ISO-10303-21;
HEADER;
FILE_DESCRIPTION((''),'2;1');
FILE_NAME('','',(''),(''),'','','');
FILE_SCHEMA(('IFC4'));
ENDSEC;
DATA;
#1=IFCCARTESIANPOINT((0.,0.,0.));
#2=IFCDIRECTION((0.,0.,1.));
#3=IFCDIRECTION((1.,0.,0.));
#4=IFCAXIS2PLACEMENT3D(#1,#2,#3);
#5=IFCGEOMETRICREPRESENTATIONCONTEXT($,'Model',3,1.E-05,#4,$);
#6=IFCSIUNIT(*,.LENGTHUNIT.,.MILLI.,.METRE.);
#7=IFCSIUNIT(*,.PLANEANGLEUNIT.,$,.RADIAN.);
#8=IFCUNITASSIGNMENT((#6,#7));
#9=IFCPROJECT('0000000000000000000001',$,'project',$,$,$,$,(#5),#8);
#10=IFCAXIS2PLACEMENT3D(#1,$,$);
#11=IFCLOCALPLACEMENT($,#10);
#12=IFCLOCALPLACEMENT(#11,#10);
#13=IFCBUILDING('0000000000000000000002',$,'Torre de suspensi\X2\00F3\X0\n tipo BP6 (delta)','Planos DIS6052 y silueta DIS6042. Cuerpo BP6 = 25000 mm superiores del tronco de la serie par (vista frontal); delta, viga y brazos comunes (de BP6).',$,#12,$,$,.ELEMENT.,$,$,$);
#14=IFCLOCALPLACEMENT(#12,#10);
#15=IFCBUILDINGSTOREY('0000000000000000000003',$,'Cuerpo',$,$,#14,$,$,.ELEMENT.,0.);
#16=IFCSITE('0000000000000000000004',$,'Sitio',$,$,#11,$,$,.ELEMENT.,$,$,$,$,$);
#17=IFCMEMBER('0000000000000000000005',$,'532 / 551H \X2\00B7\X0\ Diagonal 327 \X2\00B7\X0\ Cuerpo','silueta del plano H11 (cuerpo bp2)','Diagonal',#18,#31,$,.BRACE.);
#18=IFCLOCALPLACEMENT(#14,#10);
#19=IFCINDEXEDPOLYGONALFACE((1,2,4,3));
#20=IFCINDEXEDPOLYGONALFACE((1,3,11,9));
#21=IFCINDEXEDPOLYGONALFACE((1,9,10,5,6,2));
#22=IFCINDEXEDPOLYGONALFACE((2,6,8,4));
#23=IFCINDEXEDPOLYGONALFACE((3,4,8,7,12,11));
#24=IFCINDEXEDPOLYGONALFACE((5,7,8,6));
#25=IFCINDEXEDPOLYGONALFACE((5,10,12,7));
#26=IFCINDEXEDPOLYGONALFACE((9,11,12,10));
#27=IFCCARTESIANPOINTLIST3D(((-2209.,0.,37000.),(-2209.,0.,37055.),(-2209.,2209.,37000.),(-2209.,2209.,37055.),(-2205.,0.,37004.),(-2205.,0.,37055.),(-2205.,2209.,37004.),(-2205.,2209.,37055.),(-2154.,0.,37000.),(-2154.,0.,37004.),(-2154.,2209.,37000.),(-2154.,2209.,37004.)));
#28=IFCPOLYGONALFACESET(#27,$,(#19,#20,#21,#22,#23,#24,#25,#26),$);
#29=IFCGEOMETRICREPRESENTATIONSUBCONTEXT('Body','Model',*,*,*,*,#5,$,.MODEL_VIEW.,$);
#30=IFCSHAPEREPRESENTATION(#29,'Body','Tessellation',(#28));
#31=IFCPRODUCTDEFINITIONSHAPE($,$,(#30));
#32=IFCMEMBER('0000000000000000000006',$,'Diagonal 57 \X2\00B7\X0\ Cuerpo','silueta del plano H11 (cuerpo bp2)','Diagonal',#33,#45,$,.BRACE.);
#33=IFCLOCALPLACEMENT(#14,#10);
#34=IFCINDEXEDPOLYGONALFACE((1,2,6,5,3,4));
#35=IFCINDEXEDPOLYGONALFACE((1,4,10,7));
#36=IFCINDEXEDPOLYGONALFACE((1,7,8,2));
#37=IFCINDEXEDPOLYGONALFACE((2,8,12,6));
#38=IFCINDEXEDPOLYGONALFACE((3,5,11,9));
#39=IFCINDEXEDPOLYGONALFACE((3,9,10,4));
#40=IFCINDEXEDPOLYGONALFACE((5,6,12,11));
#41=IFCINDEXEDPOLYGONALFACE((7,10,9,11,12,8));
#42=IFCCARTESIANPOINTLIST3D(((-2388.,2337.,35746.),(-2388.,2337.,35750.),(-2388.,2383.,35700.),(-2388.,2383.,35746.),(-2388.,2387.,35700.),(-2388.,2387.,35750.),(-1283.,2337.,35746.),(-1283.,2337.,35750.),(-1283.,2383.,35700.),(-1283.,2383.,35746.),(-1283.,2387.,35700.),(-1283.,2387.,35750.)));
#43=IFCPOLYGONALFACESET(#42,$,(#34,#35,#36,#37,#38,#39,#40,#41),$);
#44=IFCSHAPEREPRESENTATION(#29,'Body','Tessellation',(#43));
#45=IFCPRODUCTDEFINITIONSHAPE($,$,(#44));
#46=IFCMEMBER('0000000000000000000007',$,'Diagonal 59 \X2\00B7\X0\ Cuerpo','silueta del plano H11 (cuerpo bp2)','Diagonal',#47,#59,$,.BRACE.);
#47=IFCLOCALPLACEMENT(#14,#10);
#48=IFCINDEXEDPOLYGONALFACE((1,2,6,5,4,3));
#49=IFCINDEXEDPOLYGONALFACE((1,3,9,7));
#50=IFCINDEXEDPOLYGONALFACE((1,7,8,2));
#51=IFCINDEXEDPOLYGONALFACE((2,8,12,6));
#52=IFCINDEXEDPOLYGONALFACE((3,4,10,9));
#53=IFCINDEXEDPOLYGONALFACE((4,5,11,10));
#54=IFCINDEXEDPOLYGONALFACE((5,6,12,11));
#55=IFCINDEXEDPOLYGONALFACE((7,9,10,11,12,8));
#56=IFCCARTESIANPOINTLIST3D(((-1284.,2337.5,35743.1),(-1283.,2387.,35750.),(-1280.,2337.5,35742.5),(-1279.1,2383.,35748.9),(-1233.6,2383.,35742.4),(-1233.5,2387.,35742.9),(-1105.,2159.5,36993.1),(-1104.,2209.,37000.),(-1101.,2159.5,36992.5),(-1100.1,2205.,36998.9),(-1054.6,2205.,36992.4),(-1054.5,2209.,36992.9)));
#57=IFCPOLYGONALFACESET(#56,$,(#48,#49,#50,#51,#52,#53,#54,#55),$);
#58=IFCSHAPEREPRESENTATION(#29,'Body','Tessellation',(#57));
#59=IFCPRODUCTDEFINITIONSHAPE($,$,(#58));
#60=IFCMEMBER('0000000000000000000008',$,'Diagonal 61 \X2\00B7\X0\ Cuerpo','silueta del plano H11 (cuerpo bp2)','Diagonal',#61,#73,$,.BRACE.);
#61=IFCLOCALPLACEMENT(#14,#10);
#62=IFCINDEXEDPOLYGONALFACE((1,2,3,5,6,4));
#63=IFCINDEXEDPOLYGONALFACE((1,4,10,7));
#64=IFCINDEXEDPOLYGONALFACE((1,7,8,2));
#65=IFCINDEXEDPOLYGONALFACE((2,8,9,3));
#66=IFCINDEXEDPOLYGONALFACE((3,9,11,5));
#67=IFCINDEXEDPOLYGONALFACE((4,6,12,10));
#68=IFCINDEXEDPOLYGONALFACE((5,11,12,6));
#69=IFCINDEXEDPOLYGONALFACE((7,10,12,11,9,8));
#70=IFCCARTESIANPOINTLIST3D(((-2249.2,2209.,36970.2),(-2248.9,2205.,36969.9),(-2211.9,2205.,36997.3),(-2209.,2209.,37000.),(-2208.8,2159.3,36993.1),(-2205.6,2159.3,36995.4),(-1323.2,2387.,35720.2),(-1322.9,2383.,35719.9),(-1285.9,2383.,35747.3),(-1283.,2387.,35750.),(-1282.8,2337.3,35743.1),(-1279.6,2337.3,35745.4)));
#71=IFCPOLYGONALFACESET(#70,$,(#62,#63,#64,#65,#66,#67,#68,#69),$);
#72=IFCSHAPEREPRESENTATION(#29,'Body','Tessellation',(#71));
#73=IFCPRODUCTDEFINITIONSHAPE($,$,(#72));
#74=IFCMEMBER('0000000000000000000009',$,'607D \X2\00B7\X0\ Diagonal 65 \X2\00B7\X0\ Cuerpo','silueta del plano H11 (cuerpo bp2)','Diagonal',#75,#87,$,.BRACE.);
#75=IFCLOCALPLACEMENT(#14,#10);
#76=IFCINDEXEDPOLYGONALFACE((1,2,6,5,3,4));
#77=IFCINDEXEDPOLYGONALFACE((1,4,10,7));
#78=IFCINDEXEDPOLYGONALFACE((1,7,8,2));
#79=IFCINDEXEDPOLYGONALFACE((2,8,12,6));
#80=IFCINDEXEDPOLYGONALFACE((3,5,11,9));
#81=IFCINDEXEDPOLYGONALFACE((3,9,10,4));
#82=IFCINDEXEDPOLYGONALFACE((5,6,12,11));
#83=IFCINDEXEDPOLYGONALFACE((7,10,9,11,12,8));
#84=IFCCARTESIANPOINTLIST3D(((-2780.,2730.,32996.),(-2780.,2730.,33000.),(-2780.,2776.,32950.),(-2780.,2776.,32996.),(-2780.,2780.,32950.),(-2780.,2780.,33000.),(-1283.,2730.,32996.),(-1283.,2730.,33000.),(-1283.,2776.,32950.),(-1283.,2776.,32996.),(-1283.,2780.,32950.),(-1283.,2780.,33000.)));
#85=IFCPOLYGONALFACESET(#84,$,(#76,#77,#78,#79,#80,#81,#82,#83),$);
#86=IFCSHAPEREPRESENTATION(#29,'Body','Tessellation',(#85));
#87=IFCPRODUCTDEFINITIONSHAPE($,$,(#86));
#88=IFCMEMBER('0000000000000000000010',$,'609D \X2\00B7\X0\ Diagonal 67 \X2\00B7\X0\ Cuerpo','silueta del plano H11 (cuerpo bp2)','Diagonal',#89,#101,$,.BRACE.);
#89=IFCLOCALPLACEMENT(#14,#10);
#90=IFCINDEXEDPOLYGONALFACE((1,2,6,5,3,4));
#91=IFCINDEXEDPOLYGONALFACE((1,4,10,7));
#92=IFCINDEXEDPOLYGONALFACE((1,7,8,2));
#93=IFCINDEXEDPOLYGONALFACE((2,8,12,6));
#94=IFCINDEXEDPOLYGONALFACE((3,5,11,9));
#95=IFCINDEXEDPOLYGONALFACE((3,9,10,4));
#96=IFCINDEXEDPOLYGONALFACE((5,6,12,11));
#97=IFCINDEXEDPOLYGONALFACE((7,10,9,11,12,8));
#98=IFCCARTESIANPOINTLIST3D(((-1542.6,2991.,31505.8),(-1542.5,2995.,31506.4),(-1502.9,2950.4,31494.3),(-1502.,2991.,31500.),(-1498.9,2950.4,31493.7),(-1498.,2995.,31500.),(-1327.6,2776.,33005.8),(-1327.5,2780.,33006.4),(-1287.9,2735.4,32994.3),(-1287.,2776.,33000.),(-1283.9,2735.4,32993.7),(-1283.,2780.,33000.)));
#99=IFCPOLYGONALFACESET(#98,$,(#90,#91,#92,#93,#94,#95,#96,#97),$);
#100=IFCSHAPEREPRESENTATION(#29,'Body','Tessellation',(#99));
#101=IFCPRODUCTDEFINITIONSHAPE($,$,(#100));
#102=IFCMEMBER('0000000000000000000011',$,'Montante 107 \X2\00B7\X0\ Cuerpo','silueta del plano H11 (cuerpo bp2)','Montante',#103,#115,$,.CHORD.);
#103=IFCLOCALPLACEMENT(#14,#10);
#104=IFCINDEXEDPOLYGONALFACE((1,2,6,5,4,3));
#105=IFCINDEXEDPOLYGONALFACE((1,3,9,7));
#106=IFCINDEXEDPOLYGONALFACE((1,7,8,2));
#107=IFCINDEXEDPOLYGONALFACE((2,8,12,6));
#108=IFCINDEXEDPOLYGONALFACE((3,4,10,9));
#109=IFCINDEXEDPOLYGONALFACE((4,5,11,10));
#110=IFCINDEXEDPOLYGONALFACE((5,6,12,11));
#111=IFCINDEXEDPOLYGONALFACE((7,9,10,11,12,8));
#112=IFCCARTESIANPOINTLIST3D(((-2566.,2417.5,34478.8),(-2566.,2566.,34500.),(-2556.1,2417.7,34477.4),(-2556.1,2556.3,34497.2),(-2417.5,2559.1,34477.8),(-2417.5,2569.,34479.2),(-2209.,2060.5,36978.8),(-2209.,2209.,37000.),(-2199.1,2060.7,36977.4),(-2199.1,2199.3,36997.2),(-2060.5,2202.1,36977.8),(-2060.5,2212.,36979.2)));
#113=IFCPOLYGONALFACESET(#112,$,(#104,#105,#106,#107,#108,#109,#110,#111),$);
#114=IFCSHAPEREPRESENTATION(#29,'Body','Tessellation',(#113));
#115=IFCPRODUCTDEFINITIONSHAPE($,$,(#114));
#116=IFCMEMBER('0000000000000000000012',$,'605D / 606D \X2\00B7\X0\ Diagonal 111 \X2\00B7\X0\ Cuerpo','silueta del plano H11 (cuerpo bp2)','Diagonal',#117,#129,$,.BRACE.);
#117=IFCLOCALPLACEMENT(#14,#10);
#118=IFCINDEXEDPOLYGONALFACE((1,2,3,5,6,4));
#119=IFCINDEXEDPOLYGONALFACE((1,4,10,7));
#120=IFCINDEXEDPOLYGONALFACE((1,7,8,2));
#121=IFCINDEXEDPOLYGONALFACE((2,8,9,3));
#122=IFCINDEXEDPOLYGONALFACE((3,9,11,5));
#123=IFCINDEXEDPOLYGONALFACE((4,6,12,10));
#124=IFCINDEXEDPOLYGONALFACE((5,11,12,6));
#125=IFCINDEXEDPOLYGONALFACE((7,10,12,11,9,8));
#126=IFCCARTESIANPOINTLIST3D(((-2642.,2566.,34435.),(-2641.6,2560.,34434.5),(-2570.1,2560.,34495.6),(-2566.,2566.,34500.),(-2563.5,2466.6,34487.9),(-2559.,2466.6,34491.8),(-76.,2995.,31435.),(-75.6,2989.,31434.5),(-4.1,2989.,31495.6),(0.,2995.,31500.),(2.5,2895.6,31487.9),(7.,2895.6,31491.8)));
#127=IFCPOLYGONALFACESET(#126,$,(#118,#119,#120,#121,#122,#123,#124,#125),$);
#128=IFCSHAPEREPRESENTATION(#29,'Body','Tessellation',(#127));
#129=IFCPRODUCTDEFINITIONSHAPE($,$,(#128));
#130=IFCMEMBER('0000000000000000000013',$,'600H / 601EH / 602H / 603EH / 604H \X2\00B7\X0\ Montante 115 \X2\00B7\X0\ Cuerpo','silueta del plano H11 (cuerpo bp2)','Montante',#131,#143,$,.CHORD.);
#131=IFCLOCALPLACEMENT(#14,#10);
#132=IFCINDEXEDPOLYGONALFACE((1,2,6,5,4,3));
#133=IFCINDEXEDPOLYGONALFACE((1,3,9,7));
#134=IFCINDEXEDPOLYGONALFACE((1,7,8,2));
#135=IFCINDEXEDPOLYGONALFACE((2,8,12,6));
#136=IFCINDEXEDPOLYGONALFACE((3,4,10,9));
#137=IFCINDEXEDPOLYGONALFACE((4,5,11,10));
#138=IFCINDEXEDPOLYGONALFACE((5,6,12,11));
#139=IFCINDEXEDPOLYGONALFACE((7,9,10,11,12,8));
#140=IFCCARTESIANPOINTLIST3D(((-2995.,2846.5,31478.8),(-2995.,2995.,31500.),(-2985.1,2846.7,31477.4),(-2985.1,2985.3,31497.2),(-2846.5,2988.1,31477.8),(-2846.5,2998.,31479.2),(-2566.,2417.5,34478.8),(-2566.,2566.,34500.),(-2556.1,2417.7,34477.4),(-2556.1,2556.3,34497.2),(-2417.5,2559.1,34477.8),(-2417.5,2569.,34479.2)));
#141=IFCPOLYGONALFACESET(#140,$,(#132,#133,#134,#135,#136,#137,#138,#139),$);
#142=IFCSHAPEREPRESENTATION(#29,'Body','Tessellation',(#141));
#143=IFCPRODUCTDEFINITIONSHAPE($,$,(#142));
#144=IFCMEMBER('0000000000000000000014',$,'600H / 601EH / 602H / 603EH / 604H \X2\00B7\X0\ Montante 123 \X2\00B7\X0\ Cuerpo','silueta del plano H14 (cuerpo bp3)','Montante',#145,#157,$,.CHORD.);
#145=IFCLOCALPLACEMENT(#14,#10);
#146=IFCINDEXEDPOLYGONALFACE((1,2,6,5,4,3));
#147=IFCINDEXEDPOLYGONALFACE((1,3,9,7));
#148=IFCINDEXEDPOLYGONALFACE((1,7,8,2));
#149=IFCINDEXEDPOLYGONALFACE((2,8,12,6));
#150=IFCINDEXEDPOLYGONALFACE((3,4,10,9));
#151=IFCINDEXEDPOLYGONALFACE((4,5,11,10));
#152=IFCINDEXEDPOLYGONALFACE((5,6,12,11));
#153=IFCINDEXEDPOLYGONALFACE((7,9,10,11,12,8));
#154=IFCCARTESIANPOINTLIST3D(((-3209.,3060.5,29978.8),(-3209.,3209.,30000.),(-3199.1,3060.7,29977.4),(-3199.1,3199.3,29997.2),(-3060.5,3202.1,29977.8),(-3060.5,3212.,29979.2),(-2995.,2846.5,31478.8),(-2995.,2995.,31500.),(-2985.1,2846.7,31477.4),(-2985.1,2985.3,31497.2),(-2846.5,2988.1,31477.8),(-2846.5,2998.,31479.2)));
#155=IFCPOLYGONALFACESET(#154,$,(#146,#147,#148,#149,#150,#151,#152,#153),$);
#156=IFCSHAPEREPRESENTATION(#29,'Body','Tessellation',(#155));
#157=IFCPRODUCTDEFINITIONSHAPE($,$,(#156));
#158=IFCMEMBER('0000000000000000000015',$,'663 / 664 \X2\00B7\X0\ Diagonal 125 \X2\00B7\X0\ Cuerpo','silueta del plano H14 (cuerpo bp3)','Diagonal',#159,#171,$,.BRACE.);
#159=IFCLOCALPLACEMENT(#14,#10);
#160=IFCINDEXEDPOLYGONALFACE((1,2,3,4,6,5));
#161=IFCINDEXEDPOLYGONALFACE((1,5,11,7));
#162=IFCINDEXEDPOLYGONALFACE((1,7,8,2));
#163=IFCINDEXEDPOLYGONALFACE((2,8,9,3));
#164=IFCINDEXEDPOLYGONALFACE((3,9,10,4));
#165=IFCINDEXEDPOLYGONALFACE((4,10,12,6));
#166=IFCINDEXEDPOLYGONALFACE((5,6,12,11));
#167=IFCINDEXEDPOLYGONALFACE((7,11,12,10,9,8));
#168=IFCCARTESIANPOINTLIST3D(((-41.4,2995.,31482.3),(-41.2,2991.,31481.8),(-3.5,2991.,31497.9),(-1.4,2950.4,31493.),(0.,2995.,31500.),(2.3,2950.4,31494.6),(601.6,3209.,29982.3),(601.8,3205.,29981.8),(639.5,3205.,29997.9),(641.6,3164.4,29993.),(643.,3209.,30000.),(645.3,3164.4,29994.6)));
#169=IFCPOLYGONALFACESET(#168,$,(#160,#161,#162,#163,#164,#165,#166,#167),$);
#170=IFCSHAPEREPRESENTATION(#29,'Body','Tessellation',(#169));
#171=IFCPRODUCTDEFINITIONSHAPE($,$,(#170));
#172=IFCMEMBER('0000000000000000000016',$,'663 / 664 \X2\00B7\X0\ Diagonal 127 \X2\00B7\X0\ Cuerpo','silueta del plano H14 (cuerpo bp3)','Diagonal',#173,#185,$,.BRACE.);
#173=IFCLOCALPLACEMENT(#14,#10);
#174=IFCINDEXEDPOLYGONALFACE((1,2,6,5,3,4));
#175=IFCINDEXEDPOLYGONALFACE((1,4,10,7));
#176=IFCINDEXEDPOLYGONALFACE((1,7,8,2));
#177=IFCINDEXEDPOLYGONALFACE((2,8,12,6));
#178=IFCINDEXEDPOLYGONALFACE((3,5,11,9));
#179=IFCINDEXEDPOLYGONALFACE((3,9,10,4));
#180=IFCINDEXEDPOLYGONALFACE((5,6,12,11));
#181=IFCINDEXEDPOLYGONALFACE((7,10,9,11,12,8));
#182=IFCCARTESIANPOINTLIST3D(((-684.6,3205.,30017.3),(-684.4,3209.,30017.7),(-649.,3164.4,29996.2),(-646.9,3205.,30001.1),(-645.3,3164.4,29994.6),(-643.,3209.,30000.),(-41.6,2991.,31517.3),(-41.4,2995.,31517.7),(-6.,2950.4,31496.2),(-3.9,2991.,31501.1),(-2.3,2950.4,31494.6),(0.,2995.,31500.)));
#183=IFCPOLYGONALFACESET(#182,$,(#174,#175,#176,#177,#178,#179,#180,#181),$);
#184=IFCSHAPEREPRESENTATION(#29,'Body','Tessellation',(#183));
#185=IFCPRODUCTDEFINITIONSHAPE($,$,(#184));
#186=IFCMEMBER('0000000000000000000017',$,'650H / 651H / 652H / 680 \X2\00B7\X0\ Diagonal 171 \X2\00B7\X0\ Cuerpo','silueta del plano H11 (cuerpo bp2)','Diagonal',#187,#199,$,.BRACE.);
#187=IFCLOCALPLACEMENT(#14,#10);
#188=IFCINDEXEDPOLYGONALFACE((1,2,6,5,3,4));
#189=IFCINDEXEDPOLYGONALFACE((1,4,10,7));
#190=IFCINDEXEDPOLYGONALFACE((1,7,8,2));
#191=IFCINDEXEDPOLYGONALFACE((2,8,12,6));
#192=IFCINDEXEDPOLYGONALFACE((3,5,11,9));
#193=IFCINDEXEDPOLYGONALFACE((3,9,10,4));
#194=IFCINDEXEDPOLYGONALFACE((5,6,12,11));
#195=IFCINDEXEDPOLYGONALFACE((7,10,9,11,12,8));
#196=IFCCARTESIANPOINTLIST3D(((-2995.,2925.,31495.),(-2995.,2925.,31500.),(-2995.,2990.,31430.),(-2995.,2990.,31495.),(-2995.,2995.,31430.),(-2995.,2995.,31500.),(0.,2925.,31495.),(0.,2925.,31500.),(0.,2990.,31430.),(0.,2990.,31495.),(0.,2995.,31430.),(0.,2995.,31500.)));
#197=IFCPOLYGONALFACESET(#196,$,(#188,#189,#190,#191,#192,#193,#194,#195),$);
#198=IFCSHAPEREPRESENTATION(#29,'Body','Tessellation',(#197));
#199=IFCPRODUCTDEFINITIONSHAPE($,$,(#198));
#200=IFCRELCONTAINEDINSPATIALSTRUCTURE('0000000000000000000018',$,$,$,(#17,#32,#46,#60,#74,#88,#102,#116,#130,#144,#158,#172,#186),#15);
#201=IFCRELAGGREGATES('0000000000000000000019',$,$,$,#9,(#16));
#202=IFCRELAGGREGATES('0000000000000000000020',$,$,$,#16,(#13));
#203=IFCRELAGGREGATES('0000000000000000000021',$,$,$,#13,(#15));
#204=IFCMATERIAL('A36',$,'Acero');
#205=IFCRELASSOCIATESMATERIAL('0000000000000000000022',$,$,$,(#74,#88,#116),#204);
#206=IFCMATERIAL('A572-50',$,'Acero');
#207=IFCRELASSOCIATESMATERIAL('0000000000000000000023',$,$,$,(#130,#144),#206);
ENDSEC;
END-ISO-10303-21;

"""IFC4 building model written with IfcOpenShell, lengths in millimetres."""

from ifc_helpers import new_model, si_unit, frame, frame_2d, origin, origin_with_axes, place, context, subcontext, project, spatial, l_section, extrude, material, element, save


model = new_model("IFC4")

# Units and contexts
model_context = context("Model", 3, precision=1e-05, world=origin_with_axes())
body_context = subcontext(model_context, "Body", "Model", "MODEL_VIEW")
ifc_project = project(units=[si_unit("LENGTHUNIT", "METRE", prefix="MILLI"), si_unit("PLANEANGLEUNIT", "RADIAN")], contexts=[model_context])

# Site, building, storey
site_placement = place(None, origin())
site = spatial("IfcSite", under=ifc_project, at=site_placement, Name="Sitio", CompositionType="ELEMENT")
building_placement = place(site_placement, origin())
building = spatial("IfcBuilding", under=site, at=building_placement, Name="Torre de suspensión tipo BP6 (delta)", Description="Planos DIS6052 y silueta DIS6042. Cuerpo BP6 = 25000 mm superiores del tronco de la serie par (vista frontal); delta, viga y brazos comunes (de BP6).", CompositionType="ELEMENT")
storey_placement = place(building_placement, origin())
storey = spatial("IfcBuildingStorey", under=building, at=storey_placement, Name="Cuerpo", CompositionType="ELEMENT", Elevation=0.0)

# Members
member_1_placement = place(storey_placement, frame((-2209.0, 2209.0, 37000.0), z_axis=(0.0, -1.0, 0.0), x_axis=(1.0, 0.0, 0.0)))
element("IfcMember", 1, at=member_1_placement, inside=storey, Name="532 / 551H · Diagonal 327 · Cuerpo", Description="silueta del plano H11 (cuerpo bp2)", ObjectType="Diagonal", PredefinedType="BRACE", context=body_context, shape_type="SweptSolid", body=[
    extrude(l_section(Depth=55.0, Width=55.0, Thickness=4.0, at=frame_2d((27.5, 27.5))), None, (0.0, 0.0, 1.0), 2209.0),
])
member_2_placement = place(storey_placement, frame((-2388.0, 2387.0, 35750.0), z_axis=(1.0, 0.0, 0.0), x_axis=(0.0, -1.0, 0.0)))
element("IfcMember", 2, at=member_2_placement, inside=storey, Name="Diagonal 57 · Cuerpo", Description="silueta del plano H11 (cuerpo bp2)", ObjectType="Diagonal", PredefinedType="BRACE", context=body_context, shape_type="SweptSolid", body=[
    extrude(l_section(Depth=50.0, Width=50.0, Thickness=4.0, at=frame_2d((25.0, 25.0))), None, (0.0, 0.0, 1.0), 1105.0),
])
member_3_placement = place(storey_placement, frame((-1283.0, 2387.0, 35750.0), z_axis=(0.140366, -0.139582, 0.980211), x_axis=(-0.019786, -0.990211, -0.138173)))
element("IfcMember", 3, at=member_3_placement, inside=storey, Name="Diagonal 59 · Cuerpo", Description="silueta del plano H11 (cuerpo bp2)", ObjectType="Diagonal", PredefinedType="BRACE", context=body_context, shape_type="SweptSolid", body=[
    extrude(l_section(Depth=50.0, Width=50.0, Thickness=4.0, at=frame_2d((25.0, 25.0))), None, (0.0, 0.0, 1.0), 1275.2),
])
member_4_placement = place(storey_placement, frame((-2209.0, 2209.0, 37000.0), z_axis=(0.591399, 0.113682, -0.798325), x_axis=(0.06767, -0.993517, -0.091347)))
element("IfcMember", 4, at=member_4_placement, inside=storey, Name="Diagonal 61 · Cuerpo", Description="silueta del plano H11 (cuerpo bp2)", ObjectType="Diagonal", PredefinedType="BRACE", context=body_context, shape_type="SweptSolid", body=[
    extrude(l_section(Depth=50.0, Width=50.0, Thickness=4.0, at=frame_2d((25.0, 25.0))), None, (0.0, 0.0, 1.0), 1565.8),
])
ifc_material_1 = material(Name="A36", Category="Acero")
member_5_placement = place(storey_placement, frame((-2780.0, 2780.0, 33000.0), z_axis=(1.0, 0.0, 0.0), x_axis=(0.0, -1.0, 0.0)))
element("IfcMember", 5, at=member_5_placement, inside=storey, material=ifc_material_1, Name="607D · Diagonal 65 · Cuerpo", Description="silueta del plano H11 (cuerpo bp2)", ObjectType="Diagonal", PredefinedType="BRACE", context=body_context, shape_type="SweptSolid", body=[
    extrude(l_section(Depth=50.0, Width=50.0, Thickness=4.0, at=frame_2d((25.0, 25.0))), None, (0.0, 0.0, 1.0), 1497.0),
])
member_6_placement = place(storey_placement, frame((-1283.0, 2780.0, 33000.0), z_axis=(-0.140476, 0.140476, -0.980068), x_axis=(-0.019931, -0.990084, -0.139055)))
element("IfcMember", 6, at=member_6_placement, inside=storey, material=ifc_material_1, Name="609D · Diagonal 67 · Cuerpo", Description="silueta del plano H11 (cuerpo bp2)", ObjectType="Diagonal", PredefinedType="BRACE", context=body_context, shape_type="SweptSolid", body=[
    extrude(l_section(Depth=45.0, Width=45.0, Thickness=4.0, at=frame_2d((22.5, 22.5))), None, (0.0, 0.0, 1.0), 1530.5),
])
member_7_placement = place(storey_placement, frame((-2209.0, 2209.0, 37000.0), z_axis=(-0.139974, 0.139974, -0.980211), x_axis=(0.990155, 0.019788, -0.138568)))
element("IfcMember", 7, at=member_7_placement, inside=storey, Name="Montante 107 · Cuerpo", Description="silueta del plano H11 (cuerpo bp2)", ObjectType="Montante", PredefinedType="CHORD", context=body_context, shape_type="SweptSolid", body=[
    extrude(l_section(Depth=150.0, Width=150.0, Thickness=10.0, at=frame_2d((75.0, 75.0))), None, (0.0, 0.0, 1.0), 2550.5),
])
member_8_placement = place(storey_placement, frame((-2566.0, 2566.0, 34500.0), z_axis=(0.646194, 0.108035, -0.755488), x_axis=(0.070222, -0.994147, -0.082099)))
element("IfcMember", 8, at=member_8_placement, inside=storey, material=ifc_material_1, Name="605D / 606D · Diagonal 111 · Cuerpo", Description="silueta del plano H11 (cuerpo bp2)", ObjectType="Diagonal", PredefinedType="BRACE", context=body_context, shape_type="SweptSolid", body=[
    extrude(l_section(Depth=100.0, Width=100.0, Thickness=6.0, at=frame_2d((50.0, 50.0))), None, (0.0, 0.0, 1.0), 3970.9),
])
ifc_material_2 = material(Name="A572-50", Category="Acero")
member_9_placement = place(storey_placement, frame((-2566.0, 2566.0, 34500.0), z_axis=(-0.140163, 0.140163, -0.980158), x_axis=(0.990129, 0.019841, -0.138751)))
element("IfcMember", 9, at=member_9_placement, inside=storey, material=ifc_material_2, Name="600H / 601EH / 602H / 603EH / 604H · Montante 115 · Cuerpo", Description="silueta del plano H11 (cuerpo bp2)", ObjectType="Montante", PredefinedType="CHORD", context=body_context, shape_type="SweptSolid", body=[
    extrude(l_section(Depth=150.0, Width=150.0, Thickness=10.0, at=frame_2d((75.0, 75.0))), None, (0.0, 0.0, 1.0), 3060.7),
])
member_10_placement = place(storey_placement, frame((-2995.0, 2995.0, 31500.0), z_axis=(-0.139849, 0.139849, -0.980247), x_axis=(0.990173, 0.019752, -0.138447)))
element("IfcMember", 10, at=member_10_placement, inside=storey, material=ifc_material_2, Name="600H / 601EH / 602H / 603EH / 604H · Montante 123 · Cuerpo", Description="silueta del plano H14 (cuerpo bp3)", ObjectType="Montante", PredefinedType="CHORD", context=body_context, shape_type="SweptSolid", body=[
    extrude(l_section(Depth=150.0, Width=150.0, Thickness=10.0, at=frame_2d((75.0, 75.0))), None, (0.0, 0.0, 1.0), 1530.2),
])
for number, where, z_axis, x_axis, name in (
    (11, (0.0, 2995.0, 31500.0), (0.390649, 0.130014, -0.911312), (0.051225, -0.991512, -0.119497), "663 / 664 · Diagonal 125 · Cuerpo"),
    (12, (0.0, 2995.0, 31500.0), (-0.390649, 0.130014, -0.911312), (-0.051225, -0.991512, -0.119497), "663 / 664 · Diagonal 127 · Cuerpo"),
):
    element("IfcMember", number, at=place(storey_placement, frame(where, z_axis=z_axis, x_axis=x_axis)), inside=storey, Name=name, Description="silueta del plano H14 (cuerpo bp3)", ObjectType="Diagonal", PredefinedType="BRACE", context=body_context, shape_type="SweptSolid", body=[
        extrude(l_section(Depth=45.0, Width=45.0, Thickness=4.0, at=frame_2d((22.5, 22.5))), None, (0.0, 0.0, 1.0), 1646.0),
    ])
member_11_placement = place(storey_placement, frame((-2995.0, 2995.0, 31500.0), z_axis=(1.0, 0.0, 0.0), x_axis=(0.0, -1.0, 0.0)))
element("IfcMember", 13, at=member_11_placement, inside=storey, Name="650H / 651H / 652H / 680 · Diagonal 171 · Cuerpo", Description="silueta del plano H11 (cuerpo bp2)", ObjectType="Diagonal", PredefinedType="BRACE", context=body_context, shape_type="SweptSolid", body=[
    extrude(l_section(Depth=70.0, Width=70.0, Thickness=5.0, at=frame_2d((35.0, 35.0))), None, (0.0, 0.0, 1.0), 2995.0),
])

save(model, "model.ifc")
